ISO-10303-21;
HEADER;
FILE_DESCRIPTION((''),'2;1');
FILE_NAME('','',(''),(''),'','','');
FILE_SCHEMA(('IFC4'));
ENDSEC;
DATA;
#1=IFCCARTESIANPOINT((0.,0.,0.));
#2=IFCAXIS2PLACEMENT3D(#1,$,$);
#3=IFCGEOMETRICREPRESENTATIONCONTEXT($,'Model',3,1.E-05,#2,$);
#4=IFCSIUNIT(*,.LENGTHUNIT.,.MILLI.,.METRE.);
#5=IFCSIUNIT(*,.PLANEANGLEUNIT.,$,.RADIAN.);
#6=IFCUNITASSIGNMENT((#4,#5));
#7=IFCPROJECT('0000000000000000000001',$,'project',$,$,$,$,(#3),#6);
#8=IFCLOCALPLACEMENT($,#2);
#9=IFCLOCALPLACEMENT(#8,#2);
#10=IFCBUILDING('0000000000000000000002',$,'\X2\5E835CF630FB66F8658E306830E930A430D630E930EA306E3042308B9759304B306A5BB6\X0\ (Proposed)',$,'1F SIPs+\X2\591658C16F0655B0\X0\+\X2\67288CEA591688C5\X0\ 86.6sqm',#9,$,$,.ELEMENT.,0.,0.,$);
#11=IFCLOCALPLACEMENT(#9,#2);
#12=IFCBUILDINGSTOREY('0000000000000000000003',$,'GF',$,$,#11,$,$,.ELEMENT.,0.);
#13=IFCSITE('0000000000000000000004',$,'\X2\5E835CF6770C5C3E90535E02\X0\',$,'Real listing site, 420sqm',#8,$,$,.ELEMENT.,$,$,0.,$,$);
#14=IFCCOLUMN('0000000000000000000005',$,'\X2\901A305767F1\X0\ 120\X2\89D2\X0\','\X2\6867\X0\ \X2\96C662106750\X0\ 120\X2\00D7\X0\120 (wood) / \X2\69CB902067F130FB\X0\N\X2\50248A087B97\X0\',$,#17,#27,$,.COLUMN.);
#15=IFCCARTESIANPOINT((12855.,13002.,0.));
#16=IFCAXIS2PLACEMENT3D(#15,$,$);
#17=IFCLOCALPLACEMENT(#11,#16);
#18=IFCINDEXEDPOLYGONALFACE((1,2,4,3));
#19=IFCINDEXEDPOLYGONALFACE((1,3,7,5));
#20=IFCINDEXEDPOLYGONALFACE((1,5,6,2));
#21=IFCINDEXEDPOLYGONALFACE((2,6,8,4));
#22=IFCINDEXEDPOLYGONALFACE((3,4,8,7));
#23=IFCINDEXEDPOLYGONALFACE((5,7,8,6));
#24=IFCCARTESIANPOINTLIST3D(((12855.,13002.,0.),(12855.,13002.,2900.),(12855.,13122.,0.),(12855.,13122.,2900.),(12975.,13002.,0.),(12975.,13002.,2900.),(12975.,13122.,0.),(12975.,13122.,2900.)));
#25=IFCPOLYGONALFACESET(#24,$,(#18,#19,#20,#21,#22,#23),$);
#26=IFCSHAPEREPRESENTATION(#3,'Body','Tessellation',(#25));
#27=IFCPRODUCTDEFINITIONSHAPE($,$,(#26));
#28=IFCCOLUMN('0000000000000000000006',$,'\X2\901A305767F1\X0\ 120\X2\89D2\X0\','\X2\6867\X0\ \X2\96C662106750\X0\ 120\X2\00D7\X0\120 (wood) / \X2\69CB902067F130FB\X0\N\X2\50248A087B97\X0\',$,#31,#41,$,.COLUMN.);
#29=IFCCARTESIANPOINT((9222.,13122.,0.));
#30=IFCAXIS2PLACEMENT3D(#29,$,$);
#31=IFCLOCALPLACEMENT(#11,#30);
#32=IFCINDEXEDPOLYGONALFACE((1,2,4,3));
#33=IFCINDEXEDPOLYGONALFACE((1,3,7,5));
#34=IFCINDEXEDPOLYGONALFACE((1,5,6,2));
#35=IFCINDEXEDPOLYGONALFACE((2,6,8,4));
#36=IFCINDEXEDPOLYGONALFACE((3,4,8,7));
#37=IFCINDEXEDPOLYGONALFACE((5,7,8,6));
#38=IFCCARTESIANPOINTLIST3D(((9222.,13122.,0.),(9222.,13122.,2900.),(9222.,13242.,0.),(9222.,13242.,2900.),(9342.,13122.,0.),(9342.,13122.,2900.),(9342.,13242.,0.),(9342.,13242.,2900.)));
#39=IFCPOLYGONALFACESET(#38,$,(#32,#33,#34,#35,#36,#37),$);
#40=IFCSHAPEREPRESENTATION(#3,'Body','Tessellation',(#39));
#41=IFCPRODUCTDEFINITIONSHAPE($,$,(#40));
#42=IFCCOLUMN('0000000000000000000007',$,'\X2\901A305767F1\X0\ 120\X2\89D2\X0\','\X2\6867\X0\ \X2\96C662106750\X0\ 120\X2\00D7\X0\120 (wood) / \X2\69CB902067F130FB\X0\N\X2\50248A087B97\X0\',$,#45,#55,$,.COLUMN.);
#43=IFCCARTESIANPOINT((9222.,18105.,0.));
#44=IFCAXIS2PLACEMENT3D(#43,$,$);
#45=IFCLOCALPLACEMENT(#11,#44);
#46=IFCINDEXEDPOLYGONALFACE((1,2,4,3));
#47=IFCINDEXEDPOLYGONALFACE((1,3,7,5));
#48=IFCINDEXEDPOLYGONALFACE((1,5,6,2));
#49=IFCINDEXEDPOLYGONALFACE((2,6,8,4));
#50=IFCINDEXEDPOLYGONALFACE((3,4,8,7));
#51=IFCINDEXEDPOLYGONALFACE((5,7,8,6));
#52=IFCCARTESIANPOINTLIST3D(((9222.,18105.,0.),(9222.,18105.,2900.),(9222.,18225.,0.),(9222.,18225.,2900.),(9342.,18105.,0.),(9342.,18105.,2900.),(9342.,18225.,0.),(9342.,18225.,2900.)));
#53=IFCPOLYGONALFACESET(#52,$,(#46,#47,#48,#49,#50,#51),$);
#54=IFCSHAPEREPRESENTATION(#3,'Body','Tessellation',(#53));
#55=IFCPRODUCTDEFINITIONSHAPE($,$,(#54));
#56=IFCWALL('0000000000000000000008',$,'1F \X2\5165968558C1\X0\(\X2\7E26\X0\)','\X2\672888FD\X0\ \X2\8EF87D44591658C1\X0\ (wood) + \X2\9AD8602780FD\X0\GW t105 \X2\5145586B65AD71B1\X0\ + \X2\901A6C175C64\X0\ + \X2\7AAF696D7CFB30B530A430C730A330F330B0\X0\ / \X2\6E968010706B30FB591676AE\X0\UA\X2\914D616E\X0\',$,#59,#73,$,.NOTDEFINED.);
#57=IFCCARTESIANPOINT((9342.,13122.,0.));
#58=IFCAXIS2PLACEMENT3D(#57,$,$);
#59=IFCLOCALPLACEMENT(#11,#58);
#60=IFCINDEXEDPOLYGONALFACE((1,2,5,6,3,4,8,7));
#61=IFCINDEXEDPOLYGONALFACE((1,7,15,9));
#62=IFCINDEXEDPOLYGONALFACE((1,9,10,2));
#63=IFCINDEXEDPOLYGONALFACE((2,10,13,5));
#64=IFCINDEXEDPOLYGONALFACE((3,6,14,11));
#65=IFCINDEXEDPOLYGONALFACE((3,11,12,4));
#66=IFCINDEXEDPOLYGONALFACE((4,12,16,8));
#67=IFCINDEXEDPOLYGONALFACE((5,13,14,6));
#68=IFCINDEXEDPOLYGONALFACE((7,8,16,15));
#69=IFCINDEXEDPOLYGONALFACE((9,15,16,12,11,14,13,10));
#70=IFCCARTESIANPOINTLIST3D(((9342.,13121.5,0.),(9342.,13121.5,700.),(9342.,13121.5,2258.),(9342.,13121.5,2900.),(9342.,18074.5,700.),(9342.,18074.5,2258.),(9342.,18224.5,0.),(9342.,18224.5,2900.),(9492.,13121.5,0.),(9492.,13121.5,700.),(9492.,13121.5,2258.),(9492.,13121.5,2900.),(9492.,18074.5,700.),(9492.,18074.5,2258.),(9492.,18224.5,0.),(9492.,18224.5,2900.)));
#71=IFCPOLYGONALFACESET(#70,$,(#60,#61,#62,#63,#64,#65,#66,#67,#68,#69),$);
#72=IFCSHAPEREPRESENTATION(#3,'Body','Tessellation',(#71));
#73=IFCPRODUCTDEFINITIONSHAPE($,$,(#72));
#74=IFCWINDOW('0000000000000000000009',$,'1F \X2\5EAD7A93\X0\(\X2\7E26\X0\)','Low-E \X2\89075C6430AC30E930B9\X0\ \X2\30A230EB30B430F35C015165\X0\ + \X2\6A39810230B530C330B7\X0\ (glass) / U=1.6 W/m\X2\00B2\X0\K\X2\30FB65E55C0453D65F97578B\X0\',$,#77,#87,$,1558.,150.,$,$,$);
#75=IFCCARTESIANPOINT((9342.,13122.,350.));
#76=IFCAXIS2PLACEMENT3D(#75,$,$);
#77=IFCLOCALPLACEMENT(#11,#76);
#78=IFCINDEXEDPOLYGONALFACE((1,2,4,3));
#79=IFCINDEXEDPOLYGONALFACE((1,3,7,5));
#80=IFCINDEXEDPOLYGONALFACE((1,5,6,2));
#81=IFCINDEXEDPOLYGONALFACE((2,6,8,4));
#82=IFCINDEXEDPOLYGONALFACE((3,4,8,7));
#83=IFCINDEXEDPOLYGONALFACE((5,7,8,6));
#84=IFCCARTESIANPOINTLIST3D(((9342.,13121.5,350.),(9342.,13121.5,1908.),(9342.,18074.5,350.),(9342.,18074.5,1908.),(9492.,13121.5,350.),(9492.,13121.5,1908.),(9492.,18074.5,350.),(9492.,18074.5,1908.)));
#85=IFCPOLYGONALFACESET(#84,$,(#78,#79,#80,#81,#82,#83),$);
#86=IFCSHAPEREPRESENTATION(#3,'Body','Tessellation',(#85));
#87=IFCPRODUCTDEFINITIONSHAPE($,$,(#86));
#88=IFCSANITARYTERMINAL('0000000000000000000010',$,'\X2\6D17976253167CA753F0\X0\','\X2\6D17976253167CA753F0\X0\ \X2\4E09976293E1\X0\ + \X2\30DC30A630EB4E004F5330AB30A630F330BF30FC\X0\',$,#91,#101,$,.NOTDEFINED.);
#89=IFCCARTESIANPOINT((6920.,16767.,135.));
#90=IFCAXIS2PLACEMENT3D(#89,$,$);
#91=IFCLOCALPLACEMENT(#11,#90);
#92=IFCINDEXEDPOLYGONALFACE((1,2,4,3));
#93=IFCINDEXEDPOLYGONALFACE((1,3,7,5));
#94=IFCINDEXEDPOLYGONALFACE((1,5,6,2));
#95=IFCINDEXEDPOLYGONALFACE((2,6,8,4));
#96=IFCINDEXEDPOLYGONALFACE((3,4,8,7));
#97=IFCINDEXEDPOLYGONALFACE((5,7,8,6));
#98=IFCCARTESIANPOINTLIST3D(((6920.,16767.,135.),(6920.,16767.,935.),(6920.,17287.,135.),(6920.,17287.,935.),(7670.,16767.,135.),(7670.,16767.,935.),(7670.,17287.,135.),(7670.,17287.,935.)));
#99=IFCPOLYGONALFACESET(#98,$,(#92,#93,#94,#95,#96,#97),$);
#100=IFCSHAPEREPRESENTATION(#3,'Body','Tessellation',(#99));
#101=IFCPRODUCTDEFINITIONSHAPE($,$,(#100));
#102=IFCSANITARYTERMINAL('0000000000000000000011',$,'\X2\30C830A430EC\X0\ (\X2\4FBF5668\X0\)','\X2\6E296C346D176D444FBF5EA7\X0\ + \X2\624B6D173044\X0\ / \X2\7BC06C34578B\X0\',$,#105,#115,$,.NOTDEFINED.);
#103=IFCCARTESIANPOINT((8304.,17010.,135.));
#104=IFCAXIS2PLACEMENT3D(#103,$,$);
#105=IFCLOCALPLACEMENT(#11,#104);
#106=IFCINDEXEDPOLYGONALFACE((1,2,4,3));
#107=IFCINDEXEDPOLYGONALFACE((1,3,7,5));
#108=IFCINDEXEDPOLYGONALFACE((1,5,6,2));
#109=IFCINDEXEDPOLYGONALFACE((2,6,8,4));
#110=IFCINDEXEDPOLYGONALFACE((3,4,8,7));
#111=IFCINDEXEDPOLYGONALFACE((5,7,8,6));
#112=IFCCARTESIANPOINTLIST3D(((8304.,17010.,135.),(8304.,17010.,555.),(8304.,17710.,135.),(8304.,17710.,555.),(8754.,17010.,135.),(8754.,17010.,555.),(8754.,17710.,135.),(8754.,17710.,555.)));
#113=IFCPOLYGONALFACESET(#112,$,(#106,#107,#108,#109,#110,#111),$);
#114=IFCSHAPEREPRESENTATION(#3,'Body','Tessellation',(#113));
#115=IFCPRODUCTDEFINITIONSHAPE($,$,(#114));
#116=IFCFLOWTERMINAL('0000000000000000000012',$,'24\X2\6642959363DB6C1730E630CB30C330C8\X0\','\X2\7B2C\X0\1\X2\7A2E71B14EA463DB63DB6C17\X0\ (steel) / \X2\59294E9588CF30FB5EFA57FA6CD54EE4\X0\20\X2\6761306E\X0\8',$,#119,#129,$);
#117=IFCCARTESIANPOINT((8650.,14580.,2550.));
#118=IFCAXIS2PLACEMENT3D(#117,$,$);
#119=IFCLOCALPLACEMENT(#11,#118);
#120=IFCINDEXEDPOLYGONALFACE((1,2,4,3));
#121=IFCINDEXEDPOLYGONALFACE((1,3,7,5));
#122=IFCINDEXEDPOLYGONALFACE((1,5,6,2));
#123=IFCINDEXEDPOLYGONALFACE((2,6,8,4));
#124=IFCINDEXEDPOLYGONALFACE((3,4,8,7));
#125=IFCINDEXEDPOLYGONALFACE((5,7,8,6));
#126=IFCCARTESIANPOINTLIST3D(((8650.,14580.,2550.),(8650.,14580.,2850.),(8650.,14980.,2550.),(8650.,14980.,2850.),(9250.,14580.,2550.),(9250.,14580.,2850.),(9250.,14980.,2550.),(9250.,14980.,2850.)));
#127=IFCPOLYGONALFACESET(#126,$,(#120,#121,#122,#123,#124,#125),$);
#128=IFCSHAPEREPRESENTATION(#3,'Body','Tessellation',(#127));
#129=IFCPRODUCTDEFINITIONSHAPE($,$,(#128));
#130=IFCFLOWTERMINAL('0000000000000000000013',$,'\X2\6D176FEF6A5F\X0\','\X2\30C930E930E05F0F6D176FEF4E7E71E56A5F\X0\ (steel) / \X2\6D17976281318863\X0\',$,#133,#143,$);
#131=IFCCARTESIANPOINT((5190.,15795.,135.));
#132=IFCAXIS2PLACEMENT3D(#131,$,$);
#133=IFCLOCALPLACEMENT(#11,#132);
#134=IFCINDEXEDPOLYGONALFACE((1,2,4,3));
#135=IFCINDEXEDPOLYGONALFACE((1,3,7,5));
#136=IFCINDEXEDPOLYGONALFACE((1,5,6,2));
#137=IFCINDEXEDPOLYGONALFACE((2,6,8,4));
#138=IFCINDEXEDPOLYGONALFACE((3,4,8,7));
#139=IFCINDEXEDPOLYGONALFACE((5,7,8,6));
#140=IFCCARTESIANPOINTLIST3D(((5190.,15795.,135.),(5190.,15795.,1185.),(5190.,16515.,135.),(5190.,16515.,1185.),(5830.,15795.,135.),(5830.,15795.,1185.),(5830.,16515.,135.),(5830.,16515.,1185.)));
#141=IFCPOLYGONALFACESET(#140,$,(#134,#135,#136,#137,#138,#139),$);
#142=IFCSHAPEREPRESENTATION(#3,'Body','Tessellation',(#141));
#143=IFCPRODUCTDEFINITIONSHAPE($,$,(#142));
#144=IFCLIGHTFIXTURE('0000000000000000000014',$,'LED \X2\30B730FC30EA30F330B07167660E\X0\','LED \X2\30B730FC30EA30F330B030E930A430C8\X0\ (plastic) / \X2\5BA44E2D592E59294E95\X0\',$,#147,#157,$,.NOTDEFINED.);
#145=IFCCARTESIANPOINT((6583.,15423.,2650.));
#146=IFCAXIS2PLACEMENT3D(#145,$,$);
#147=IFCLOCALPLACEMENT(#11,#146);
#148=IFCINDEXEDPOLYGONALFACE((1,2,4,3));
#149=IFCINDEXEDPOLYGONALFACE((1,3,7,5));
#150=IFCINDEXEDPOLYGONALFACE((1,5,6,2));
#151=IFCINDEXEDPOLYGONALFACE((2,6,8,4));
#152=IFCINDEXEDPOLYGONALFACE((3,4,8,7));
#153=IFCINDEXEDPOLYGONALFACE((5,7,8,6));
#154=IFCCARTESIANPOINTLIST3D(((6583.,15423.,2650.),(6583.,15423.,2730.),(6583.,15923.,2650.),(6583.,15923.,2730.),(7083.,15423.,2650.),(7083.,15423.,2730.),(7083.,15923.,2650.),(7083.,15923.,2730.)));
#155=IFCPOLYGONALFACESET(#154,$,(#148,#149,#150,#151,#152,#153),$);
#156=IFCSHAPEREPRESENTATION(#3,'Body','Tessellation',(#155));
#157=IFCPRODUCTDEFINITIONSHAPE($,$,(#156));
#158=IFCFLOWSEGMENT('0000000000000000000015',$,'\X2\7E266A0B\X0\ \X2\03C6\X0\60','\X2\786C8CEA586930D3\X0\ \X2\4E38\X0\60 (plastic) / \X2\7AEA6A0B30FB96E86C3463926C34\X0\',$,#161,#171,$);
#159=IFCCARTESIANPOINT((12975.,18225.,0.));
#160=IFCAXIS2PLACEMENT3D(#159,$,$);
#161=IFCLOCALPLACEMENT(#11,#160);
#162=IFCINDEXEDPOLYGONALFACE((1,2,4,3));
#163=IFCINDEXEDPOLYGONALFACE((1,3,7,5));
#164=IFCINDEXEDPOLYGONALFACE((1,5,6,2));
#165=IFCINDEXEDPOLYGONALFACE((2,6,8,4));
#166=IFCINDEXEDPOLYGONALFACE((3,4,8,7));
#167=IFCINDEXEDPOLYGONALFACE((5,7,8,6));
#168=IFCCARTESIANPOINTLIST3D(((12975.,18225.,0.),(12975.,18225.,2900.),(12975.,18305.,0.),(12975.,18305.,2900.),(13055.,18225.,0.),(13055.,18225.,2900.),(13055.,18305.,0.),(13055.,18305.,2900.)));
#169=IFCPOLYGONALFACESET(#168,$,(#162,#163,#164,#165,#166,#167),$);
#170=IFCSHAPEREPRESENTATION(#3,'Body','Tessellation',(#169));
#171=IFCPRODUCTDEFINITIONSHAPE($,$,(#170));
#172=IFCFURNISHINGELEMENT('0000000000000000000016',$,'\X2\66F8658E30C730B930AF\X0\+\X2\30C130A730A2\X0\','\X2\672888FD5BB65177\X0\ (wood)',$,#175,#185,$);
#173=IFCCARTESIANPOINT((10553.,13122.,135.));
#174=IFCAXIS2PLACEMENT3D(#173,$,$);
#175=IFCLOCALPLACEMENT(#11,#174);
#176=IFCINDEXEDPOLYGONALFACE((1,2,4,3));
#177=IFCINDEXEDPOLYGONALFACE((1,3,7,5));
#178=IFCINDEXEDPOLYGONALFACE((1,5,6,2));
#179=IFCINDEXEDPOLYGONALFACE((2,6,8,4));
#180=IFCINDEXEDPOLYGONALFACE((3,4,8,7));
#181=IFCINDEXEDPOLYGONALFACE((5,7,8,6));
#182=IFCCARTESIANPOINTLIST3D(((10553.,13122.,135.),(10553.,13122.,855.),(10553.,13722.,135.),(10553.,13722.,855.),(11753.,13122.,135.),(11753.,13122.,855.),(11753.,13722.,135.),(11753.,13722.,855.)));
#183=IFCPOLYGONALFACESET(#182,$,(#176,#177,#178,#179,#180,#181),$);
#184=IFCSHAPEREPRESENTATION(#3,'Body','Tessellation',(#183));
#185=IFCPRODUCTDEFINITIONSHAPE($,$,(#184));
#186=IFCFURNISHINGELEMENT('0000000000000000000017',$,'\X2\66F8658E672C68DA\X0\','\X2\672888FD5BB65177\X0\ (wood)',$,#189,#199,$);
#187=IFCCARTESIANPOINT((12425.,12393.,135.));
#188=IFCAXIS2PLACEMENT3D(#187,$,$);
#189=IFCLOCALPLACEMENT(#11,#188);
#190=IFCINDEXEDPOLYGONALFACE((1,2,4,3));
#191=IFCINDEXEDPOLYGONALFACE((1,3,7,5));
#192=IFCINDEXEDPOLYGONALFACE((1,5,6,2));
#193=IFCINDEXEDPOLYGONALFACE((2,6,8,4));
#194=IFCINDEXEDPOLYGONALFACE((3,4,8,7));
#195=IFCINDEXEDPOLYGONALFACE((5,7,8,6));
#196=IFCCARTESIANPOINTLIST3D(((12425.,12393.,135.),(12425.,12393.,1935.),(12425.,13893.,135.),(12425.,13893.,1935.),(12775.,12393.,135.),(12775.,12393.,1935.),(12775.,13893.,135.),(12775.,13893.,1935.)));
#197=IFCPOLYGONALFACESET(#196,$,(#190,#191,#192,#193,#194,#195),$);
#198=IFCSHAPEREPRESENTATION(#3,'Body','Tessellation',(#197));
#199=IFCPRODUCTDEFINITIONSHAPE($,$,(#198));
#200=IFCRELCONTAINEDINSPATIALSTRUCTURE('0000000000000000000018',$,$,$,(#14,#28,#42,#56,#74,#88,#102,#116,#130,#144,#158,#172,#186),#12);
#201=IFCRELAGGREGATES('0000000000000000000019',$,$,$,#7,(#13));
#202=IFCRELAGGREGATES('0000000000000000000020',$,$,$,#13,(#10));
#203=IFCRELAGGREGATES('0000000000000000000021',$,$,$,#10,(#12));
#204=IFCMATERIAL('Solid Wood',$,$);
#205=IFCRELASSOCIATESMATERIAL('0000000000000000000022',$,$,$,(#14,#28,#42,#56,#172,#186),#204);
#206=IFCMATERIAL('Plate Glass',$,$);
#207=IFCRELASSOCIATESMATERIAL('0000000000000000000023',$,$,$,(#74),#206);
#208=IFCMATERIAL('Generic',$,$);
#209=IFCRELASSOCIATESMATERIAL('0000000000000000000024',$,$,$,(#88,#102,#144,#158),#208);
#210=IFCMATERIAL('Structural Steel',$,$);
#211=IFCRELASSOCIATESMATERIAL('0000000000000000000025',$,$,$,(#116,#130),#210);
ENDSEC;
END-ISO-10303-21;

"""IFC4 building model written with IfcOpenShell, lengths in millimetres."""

from ifc_helpers import new_model, si_unit, frame, frame_2d, origin, place, context, project, spatial, rectangle, extrude, material, element, fill, save


model = new_model("IFC4")

# Units and contexts
model_context = context("Model", 3, precision=1e-05, world=origin())
ifc_project = project(units=[si_unit("LENGTHUNIT", "METRE", prefix="MILLI"), si_unit("PLANEANGLEUNIT", "RADIAN")], contexts=[model_context])

# Site, building, storey
site_placement = place(None, origin())
site = spatial("IfcSite", under=ifc_project, at=site_placement, Name="広島県尾道市", ObjectType="Real listing site, 420sqm", CompositionType="ELEMENT", RefElevation=0.0)
building_placement = place(site_placement, origin())
building = spatial("IfcBuilding", under=site, at=building_placement, Name="広島・書斎とライブラリのある静かな家 (Proposed)", ObjectType="1F SIPs+外壁漆喰+木質外装 86.6sqm", CompositionType="ELEMENT", ElevationOfRefHeight=0.0, ElevationOfTerrain=0.0)
storey_placement = place(building_placement, origin())
storey = spatial("IfcBuildingStorey", under=building, at=storey_placement, Name="GF", CompositionType="ELEMENT", Elevation=0.0)

# Columns
ifc_material_1 = material(Name="Solid Wood")
column_1_placement = place(storey_placement, frame((12855.0, 13002.0, 0.0)))
element("IfcColumn", 1, at=column_1_placement, inside=storey, material=ifc_material_1, Name="通し柱 120角", Description="桧 集成材 120×120 (wood) / 構造柱・N値計算", PredefinedType="COLUMN", context=model_context, shape_type="SweptSolid", body=[
    extrude(rectangle(XDim=120.0, YDim=120.0, at=frame_2d((60.0, 60.0))), frame((12855.0, 13002.0, 0.0)), (0.0, 0.0, 1.0), 2900.0),
])
column_2_placement = place(storey_placement, frame((9222.0, 13122.0, 0.0)))
element("IfcColumn", 2, at=column_2_placement, inside=storey, material=ifc_material_1, Name="通し柱 120角", Description="桧 集成材 120×120 (wood) / 構造柱・N値計算", PredefinedType="COLUMN", context=model_context, shape_type="SweptSolid", body=[
    extrude(rectangle(XDim=120.0, YDim=120.0, at=frame_2d((60.0, 60.0))), frame((9222.0, 13122.0, 0.0)), (0.0, 0.0, 1.0), 2900.0),
])
column_3_placement = place(storey_placement, frame((9222.0, 18105.0, 0.0)))
element("IfcColumn", 3, at=column_3_placement, inside=storey, material=ifc_material_1, Name="通し柱 120角", Description="桧 集成材 120×120 (wood) / 構造柱・N値計算", PredefinedType="COLUMN", context=model_context, shape_type="SweptSolid", body=[
    extrude(rectangle(XDim=120.0, YDim=120.0, at=frame_2d((60.0, 60.0))), frame((9222.0, 18105.0, 0.0)), (0.0, 0.0, 1.0), 2900.0),
])

# Wall, opening, window
wall_1_placement = place(storey_placement, frame((9342.0, 13122.0, 0.0)))
wall_1 = element("IfcWall", 4, at=wall_1_placement, inside=storey, material=ifc_material_1, Name="1F 入隅壁(縦)", Description="木製 軸組外壁 (wood) + 高性能GW t105 充填断熱 + 通気層 + 窯業系サイディング / 準耐火・外皮UA配慮", PredefinedType="NOTDEFINED", context=model_context, shape_type="SweptSolid", body=[
    extrude(rectangle(XDim=150.0, YDim=5103.0, at=frame_2d((75.0, 2551.0))), frame((9342.0, 13122.0, 0.0)), (0.0, 0.0, 1.0), 2900.0),
])
opening_placement = place(storey_placement, frame((9342.0, 13122.0, 350.0)))
opening = element("IfcOpeningElement", 5, at=opening_placement, cuts=wall_1, PredefinedType="NOTDEFINED", context=model_context, shape_type="SweptSolid", body=[
    extrude(rectangle(XDim=150.0, YDim=4953.0, at=frame_2d((75.0, 2476.0))), frame((9342.0, 13122.0, 350.0)), (0.0, 0.0, 1.0), 1558.0),
])
ifc_material_2 = material(Name="Plate Glass")
window_placement = place(storey_placement, frame((9342.0, 13122.0, 350.0)))
window = element("IfcWindow", 6, at=window_placement, inside=storey, material=ifc_material_2, Name="1F 庭窓(縦)", Description="Low-E 複層ガラス アルゴン封入 + 樹脂サッシ (glass) / U=1.6 W/m²K・日射取得型", OverallHeight=1558.0, OverallWidth=150.0, context=model_context, shape_type="SweptSolid", body=[
    extrude(rectangle(XDim=150.0, YDim=4953.0, at=frame_2d((75.0, 2476.0))), frame((9342.0, 13122.0, 350.0)), (0.0, 0.0, 1.0), 1558.0),
])
fill(opening, window)

# Sanitary terminals
ifc_material_3 = material(Name="Generic")
sanitary_terminal_1_placement = place(storey_placement, frame((6920.0, 16767.0, 135.0)))
element("IfcSanitaryTerminal", 7, at=sanitary_terminal_1_placement, inside=storey, material=ifc_material_3, Name="洗面化粧台", Description="洗面化粧台 三面鏡 + ボウル一体カウンター", PredefinedType="NOTDEFINED", context=model_context, shape_type="SweptSolid", body=[
    extrude(rectangle(XDim=750.0, YDim=520.0, at=frame_2d((375.0, 260.0))), frame((6920.0, 16767.0, 135.0)), (0.0, 0.0, 1.0), 800.0),
])
sanitary_terminal_2_placement = place(storey_placement, frame((8304.0, 17010.0, 135.0)))
element("IfcSanitaryTerminal", 8, at=sanitary_terminal_2_placement, inside=storey, material=ifc_material_3, Name="トイレ (便器)", Description="温水洗浄便座 + 手洗い / 節水型", PredefinedType="NOTDEFINED", context=model_context, shape_type="SweptSolid", body=[
    extrude(rectangle(XDim=450.0, YDim=700.0, at=frame_2d((225.0, 350.0))), frame((8304.0, 17010.0, 135.0)), (0.0, 0.0, 1.0), 420.0),
])

# Flow terminals
ifc_material_4 = material(Name="Structural Steel")
flow_terminal_1_placement = place(storey_placement, frame((8650.0, 14580.0, 2550.0)))
element("IfcFlowTerminal", 9, at=flow_terminal_1_placement, inside=storey, material=ifc_material_4, Name="24時間換気ユニット", Description="第1種熱交換換気 (steel) / 天井裏・建基法令20条の8", context=model_context, shape_type="SweptSolid", body=[
    extrude(rectangle(XDim=600.0, YDim=400.0, at=frame_2d((300.0, 200.0))), frame((8650.0, 14580.0, 2550.0)), (0.0, 0.0, 1.0), 300.0),
])
flow_terminal_2_placement = place(storey_placement, frame((5190.0, 15795.0, 135.0)))
element("IfcFlowTerminal", 10, at=flow_terminal_2_placement, inside=storey, material=ifc_material_4, Name="洗濯機", Description="ドラム式洗濯乾燥機 (steel) / 洗面脱衣", context=model_context, shape_type="SweptSolid", body=[
    extrude(rectangle(XDim=640.0, YDim=720.0, at=frame_2d((320.0, 360.0))), frame((5190.0, 15795.0, 135.0)), (0.0, 0.0, 1.0), 1050.0),
])

# Light fixture
light_fixture_placement = place(storey_placement, frame((6583.0, 15423.0, 2650.0)))
element("IfcLightFixture", 11, at=light_fixture_placement, inside=storey, material=ifc_material_3, Name="LED シーリング照明", Description="LED シーリングライト (plastic) / 室中央天井", PredefinedType="NOTDEFINED", context=model_context, shape_type="SweptSolid", body=[
    extrude(rectangle(XDim=500.0, YDim=500.0, at=frame_2d((250.0, 250.0))), frame((6583.0, 15423.0, 2650.0)), (0.0, 0.0, 1.0), 80.0),
])

# Flow segment
flow_segment_placement = place(storey_placement, frame((12975.0, 18225.0, 0.0)))
element("IfcFlowSegment", 12, at=flow_segment_placement, inside=storey, material=ifc_material_3, Name="縦樋 φ60", Description="硬質塩ビ 丸60 (plastic) / 竪樋・雨水排水", context=model_context, shape_type="SweptSolid", body=[
    extrude(rectangle(XDim=80.0, YDim=80.0, at=frame_2d((40.0, 40.0))), frame((12975.0, 18225.0, 0.0)), (0.0, 0.0, 1.0), 2900.0),
])

# Furnishing elements
furnishing_1_placement = place(storey_placement, frame((10553.0, 13122.0, 135.0)))
element("IfcFurnishingElement", 13, at=furnishing_1_placement, inside=storey, material=ifc_material_1, Name="書斎デスク+チェア", Description="木製家具 (wood)", context=model_context, shape_type="SweptSolid", body=[
    extrude(rectangle(XDim=1200.0, YDim=600.0, at=frame_2d((600.0, 300.0))), frame((10553.0, 13122.0, 135.0)), (0.0, 0.0, 1.0), 720.0),
])
furnishing_2_placement = place(storey_placement, frame((12425.0, 12393.0, 135.0)))
element("IfcFurnishingElement", 14, at=furnishing_2_placement, inside=storey, material=ifc_material_1, Name="書斎本棚", Description="木製家具 (wood)", context=model_context, shape_type="SweptSolid", body=[
    extrude(rectangle(XDim=350.0, YDim=1500.0, at=frame_2d((175.0, 750.0))), frame((12425.0, 12393.0, 135.0)), (0.0, 0.0, 1.0), 1800.0),
])

save(model, "model.ifc")
